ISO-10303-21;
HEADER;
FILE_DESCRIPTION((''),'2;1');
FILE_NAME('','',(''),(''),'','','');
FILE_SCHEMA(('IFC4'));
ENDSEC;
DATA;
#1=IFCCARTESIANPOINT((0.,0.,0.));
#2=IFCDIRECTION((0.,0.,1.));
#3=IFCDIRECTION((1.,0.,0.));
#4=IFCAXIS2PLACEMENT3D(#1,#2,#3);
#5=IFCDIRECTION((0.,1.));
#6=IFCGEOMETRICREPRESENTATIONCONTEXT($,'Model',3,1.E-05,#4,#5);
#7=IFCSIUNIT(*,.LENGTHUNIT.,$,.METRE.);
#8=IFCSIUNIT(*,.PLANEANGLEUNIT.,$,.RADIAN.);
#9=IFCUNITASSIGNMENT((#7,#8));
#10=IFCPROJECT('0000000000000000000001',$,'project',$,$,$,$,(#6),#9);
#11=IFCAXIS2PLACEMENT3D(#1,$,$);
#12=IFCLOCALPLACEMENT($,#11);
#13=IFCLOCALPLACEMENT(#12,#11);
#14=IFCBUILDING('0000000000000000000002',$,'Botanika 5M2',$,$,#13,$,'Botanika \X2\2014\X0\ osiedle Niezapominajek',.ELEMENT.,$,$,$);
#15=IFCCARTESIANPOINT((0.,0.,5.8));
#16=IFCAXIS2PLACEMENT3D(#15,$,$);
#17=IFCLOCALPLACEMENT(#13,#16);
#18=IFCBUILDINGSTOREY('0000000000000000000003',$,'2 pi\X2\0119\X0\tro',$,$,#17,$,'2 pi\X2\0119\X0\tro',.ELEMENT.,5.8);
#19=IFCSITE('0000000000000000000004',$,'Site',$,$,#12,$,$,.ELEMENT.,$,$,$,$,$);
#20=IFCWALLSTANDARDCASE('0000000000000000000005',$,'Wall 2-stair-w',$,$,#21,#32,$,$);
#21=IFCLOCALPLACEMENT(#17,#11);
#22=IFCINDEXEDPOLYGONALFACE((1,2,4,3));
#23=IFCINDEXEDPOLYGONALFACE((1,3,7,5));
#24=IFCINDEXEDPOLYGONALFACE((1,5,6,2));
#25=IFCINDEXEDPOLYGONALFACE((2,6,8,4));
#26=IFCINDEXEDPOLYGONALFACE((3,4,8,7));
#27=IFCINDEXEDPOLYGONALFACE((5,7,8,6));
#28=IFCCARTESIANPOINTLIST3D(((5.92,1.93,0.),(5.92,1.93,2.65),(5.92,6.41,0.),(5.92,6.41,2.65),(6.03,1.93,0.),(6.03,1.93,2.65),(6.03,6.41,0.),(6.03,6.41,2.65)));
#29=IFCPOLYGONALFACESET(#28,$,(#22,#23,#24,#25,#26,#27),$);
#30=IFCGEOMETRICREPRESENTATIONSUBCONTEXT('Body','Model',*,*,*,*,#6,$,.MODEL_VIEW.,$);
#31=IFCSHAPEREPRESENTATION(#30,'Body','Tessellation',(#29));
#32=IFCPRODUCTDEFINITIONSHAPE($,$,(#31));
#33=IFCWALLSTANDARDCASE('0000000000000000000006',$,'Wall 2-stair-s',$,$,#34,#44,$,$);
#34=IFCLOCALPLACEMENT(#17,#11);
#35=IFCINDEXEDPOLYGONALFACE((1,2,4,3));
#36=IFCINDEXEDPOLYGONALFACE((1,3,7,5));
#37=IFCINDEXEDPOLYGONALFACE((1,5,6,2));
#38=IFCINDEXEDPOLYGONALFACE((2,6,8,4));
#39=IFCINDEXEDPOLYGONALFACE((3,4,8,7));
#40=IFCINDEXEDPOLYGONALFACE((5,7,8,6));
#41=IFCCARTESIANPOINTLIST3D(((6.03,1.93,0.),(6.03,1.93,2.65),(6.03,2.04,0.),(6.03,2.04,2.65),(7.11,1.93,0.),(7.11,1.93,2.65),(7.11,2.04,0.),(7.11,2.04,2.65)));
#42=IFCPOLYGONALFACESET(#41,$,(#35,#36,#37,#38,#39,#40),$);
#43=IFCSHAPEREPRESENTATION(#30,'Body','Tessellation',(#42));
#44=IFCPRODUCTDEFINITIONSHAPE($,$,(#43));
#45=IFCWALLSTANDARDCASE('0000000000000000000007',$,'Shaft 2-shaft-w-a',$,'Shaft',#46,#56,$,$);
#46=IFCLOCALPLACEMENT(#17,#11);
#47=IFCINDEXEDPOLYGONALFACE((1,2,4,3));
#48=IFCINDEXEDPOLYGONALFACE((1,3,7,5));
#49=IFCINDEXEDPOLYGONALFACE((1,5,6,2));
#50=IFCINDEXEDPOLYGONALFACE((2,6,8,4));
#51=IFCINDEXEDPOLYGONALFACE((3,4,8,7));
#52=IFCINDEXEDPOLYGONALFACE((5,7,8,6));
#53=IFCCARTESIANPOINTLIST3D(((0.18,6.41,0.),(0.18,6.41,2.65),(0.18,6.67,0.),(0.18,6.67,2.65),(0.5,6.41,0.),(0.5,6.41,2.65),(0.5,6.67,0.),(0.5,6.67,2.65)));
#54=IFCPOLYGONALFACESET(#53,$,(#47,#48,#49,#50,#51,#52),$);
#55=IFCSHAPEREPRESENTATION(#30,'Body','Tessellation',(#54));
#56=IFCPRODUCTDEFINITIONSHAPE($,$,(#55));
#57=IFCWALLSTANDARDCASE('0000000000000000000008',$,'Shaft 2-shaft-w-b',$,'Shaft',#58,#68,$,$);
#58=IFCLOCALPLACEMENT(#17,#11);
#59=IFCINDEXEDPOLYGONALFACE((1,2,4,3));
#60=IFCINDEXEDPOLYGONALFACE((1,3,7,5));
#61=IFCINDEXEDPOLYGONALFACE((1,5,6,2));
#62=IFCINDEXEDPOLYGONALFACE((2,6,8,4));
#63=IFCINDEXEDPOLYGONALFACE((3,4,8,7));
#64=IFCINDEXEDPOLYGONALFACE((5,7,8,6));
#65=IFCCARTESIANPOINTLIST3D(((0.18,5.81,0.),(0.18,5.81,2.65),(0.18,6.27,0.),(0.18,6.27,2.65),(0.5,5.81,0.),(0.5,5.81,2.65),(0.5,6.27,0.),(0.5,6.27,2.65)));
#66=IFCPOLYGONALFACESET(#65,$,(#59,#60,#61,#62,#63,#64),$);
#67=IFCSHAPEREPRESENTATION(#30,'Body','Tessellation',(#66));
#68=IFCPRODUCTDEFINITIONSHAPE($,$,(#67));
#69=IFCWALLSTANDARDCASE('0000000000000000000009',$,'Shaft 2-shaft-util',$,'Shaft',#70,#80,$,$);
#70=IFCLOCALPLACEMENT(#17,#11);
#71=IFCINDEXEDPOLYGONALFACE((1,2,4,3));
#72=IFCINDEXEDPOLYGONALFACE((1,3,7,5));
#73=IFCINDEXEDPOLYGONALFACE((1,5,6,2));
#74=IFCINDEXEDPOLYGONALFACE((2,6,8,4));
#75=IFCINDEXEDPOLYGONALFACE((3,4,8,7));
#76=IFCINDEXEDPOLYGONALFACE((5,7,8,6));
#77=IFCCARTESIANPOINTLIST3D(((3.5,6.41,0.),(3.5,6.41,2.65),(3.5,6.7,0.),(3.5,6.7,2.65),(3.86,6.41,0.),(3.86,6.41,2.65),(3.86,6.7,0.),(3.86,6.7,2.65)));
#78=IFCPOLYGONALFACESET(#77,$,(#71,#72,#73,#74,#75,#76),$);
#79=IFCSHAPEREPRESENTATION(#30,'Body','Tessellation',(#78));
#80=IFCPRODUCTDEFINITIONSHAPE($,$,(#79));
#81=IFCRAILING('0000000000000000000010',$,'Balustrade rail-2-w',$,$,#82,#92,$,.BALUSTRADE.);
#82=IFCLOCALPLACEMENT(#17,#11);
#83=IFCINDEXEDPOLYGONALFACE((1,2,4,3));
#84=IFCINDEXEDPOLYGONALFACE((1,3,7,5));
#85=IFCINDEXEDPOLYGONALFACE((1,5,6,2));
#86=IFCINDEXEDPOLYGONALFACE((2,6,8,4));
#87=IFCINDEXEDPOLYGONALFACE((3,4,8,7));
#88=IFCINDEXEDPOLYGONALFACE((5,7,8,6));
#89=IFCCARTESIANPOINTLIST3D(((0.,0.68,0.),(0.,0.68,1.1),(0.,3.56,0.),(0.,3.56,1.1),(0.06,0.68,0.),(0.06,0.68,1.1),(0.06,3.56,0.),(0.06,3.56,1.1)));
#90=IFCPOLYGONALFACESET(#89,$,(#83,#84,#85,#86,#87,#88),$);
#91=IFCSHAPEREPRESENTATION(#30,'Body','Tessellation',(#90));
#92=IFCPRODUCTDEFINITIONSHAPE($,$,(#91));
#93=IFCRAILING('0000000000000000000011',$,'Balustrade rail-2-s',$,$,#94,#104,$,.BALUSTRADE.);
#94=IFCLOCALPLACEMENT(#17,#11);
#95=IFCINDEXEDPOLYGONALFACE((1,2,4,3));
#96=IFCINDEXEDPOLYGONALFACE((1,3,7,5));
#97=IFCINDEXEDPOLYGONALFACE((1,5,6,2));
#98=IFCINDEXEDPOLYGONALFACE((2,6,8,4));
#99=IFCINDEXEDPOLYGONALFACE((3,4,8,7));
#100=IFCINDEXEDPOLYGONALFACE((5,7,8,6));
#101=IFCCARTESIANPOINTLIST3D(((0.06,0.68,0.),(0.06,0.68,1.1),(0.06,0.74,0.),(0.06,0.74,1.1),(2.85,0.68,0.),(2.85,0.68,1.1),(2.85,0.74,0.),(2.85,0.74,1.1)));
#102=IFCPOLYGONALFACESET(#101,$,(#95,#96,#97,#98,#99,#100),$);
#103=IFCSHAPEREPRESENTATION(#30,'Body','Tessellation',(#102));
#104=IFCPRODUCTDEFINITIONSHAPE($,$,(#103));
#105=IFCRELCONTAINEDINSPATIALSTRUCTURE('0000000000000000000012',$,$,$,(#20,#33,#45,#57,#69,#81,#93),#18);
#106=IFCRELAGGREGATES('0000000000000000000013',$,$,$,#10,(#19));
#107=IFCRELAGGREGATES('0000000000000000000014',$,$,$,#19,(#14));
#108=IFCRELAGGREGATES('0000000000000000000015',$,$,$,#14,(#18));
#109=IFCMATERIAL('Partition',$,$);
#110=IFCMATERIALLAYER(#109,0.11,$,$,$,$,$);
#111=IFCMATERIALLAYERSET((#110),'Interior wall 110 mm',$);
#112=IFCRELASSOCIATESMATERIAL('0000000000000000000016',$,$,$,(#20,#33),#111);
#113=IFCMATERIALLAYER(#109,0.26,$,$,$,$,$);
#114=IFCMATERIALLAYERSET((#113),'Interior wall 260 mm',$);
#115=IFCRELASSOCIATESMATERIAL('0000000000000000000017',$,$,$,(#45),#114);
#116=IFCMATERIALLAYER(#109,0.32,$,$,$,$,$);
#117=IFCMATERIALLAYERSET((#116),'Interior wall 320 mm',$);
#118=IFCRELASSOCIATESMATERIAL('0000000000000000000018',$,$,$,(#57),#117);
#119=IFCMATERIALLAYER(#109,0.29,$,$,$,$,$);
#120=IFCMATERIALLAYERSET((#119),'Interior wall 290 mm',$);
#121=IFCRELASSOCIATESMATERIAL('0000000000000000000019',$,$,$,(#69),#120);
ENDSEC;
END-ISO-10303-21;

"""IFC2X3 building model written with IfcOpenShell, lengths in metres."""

from ifc_helpers import new_model, si_unit, direction, frame, frame_2d, origin, origin_with_axes, place, context, subcontext, project, spatial, rectangle, extrude, material, layer, layer_set, layer_usage, element, save


model = new_model("IFC2X3")

# Units and contexts
model_context = context("Model", 3, precision=1e-05, world=origin_with_axes(), true_north=direction((0.0, 1.0)))
body_context = subcontext(model_context, "Body", "Model", "MODEL_VIEW")
ifc_project = project(units=[si_unit("LENGTHUNIT", "METRE"), si_unit("PLANEANGLEUNIT", "RADIAN")], contexts=[model_context])

# Site, building, storey
site_placement = place(None, origin())
site = spatial("IfcSite", under=ifc_project, at=site_placement, Name="Site", CompositionType="ELEMENT")
building_placement = place(site_placement, origin())
building = spatial("IfcBuilding", under=site, at=building_placement, Name="Botanika 5M2", LongName="Botanika — osiedle Niezapominajek", CompositionType="ELEMENT")
storey_placement = place(building_placement, frame((0.0, 0.0, 5.8)))
storey = spatial("IfcBuildingStorey", under=building, at=storey_placement, Name="2 piętro", LongName="2 piętro", CompositionType="ELEMENT", Elevation=5.8)

# Shared definitions
ifc_material_1 = material(Name="Partition")

# Walls
ifc_layer_1 = layer(ifc_material_1, 0.11)
ifc_layer_set_1 = layer_set([ifc_layer_1], Name="Interior wall 110 mm")
ifc_layer_usage_1 = layer_usage(ifc_layer_set_1, "AXIS2", "POSITIVE", -0.055)
wall_1_placement = place(storey_placement, frame((5.975, 6.41, 0.0), z_axis=(0.0, 0.0, 1.0), x_axis=(0.0, -1.0, 0.0)))
element("IfcWallStandardCase", 1, at=wall_1_placement, inside=storey, material=ifc_layer_usage_1, Name="Wall 2-stair-w", context=body_context, shape_type="SweptSolid", body=[
    extrude(rectangle(XDim=4.48, YDim=0.11, at=frame_2d((2.24, 0.0))), origin_with_axes(), (0.0, 0.0, 1.0), 2.65),
])
wall_2_placement = place(storey_placement, frame((6.03, 1.985, 0.0)))
element("IfcWallStandardCase", 2, at=wall_2_placement, inside=storey, material=ifc_layer_usage_1, Name="Wall 2-stair-s", context=body_context, shape_type="SweptSolid", body=[
    extrude(rectangle(XDim=1.08, YDim=0.11, at=frame_2d((0.54, 0.0))), origin_with_axes(), (0.0, 0.0, 1.0), 2.65),
])
ifc_layer_2 = layer(ifc_material_1, 0.26)
ifc_layer_set_2 = layer_set([ifc_layer_2], Name="Interior wall 260 mm")
ifc_layer_usage_2 = layer_usage(ifc_layer_set_2, "AXIS2", "POSITIVE", -0.13)
wall_3_placement = place(storey_placement, frame((0.18, 6.54, 0.0)))
element("IfcWallStandardCase", 3, at=wall_3_placement, inside=storey, material=ifc_layer_usage_2, Name="Shaft 2-shaft-w-a", ObjectType="Shaft", context=body_context, shape_type="SweptSolid", body=[
    extrude(rectangle(XDim=0.32, YDim=0.26, at=frame_2d((0.16, 0.0))), origin_with_axes(), (0.0, 0.0, 1.0), 2.65),
])
ifc_layer_3 = layer(ifc_material_1, 0.32)
ifc_layer_set_3 = layer_set([ifc_layer_3], Name="Interior wall 320 mm")
ifc_layer_usage_3 = layer_usage(ifc_layer_set_3, "AXIS2", "POSITIVE", -0.16)
wall_4_placement = place(storey_placement, frame((0.34, 6.27, 0.0), z_axis=(0.0, 0.0, 1.0), x_axis=(0.0, -1.0, 0.0)))
element("IfcWallStandardCase", 4, at=wall_4_placement, inside=storey, material=ifc_layer_usage_3, Name="Shaft 2-shaft-w-b", ObjectType="Shaft", context=body_context, shape_type="SweptSolid", body=[
    extrude(rectangle(XDim=0.46, YDim=0.32, at=frame_2d((0.23, 0.0))), origin_with_axes(), (0.0, 0.0, 1.0), 2.65),
])
ifc_layer_4 = layer(ifc_material_1, 0.29)
ifc_layer_set_4 = layer_set([ifc_layer_4], Name="Interior wall 290 mm")
ifc_layer_usage_4 = layer_usage(ifc_layer_set_4, "AXIS2", "POSITIVE", -0.145)
wall_5_placement = place(storey_placement, frame((3.5, 6.555, 0.0)))
element("IfcWallStandardCase", 5, at=wall_5_placement, inside=storey, material=ifc_layer_usage_4, Name="Shaft 2-shaft-util", ObjectType="Shaft", context=body_context, shape_type="SweptSolid", body=[
    extrude(rectangle(XDim=0.36, YDim=0.29, at=frame_2d((0.18, 0.0))), origin_with_axes(), (0.0, 0.0, 1.0), 2.65),
])

# Railings
railing_1_placement = place(storey_placement, frame((0.0, 0.68, 0.0)))
element("IfcRailing", 6, at=railing_1_placement, inside=storey, Name="Balustrade rail-2-w", PredefinedType="BALUSTRADE", context=body_context, shape_type="SweptSolid", body=[
    extrude(rectangle(XDim=0.06, YDim=2.88, at=frame_2d((0.03, 1.44))), origin_with_axes(), (0.0, 0.0, 1.0), 1.1),
])
railing_2_placement = place(storey_placement, frame((0.06, 0.68, 0.0)))
element("IfcRailing", 7, at=railing_2_placement, inside=storey, Name="Balustrade rail-2-s", PredefinedType="BALUSTRADE", context=body_context, shape_type="SweptSolid", body=[
    extrude(rectangle(XDim=2.79, YDim=0.06, at=frame_2d((1.395, 0.03))), origin_with_axes(), (0.0, 0.0, 1.0), 1.1),
])

save(model, "model.ifc")
